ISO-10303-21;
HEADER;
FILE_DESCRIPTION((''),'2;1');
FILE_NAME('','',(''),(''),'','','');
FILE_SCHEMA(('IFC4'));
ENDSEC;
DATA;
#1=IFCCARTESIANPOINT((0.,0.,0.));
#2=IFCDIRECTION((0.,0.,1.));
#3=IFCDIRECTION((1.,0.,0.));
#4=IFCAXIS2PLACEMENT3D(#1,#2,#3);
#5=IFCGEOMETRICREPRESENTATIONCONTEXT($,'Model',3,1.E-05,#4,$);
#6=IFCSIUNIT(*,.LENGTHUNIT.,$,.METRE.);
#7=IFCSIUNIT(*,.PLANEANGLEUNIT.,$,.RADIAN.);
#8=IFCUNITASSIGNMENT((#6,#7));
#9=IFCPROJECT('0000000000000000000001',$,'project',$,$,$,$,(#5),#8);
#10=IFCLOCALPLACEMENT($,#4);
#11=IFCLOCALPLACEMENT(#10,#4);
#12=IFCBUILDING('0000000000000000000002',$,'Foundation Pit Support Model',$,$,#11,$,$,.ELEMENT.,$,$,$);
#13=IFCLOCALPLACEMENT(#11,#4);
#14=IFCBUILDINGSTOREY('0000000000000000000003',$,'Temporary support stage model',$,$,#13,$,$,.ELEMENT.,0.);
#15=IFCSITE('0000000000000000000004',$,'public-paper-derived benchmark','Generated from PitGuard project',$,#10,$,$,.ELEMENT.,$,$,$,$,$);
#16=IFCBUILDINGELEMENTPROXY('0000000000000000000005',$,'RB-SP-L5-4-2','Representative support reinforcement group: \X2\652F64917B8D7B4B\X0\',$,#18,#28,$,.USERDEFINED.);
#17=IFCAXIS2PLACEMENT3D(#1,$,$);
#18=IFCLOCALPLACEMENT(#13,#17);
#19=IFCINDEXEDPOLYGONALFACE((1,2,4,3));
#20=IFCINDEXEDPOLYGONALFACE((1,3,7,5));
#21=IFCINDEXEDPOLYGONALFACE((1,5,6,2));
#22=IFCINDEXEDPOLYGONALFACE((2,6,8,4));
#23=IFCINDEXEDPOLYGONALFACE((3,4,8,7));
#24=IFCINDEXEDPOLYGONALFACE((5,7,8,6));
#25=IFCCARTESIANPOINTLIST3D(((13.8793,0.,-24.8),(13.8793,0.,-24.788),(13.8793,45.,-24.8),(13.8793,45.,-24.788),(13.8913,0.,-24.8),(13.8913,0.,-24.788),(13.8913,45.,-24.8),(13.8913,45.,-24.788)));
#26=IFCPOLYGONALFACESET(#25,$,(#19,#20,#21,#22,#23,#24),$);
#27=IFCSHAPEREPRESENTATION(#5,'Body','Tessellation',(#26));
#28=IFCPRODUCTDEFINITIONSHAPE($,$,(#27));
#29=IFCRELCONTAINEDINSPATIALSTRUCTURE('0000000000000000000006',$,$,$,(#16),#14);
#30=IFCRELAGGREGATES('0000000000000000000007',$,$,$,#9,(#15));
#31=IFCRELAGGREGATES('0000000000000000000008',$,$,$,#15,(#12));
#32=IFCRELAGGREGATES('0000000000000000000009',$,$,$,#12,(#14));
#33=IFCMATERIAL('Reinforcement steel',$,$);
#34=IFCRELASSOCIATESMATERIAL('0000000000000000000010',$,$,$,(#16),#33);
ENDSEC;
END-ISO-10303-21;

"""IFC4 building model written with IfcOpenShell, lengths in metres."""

from ifc_helpers import new_model, si_unit, frame, origin_with_axes, origin_2d, place, context, project, spatial, rectangle, extrude, material, element, save


model = new_model("IFC4")

# Units and contexts
model_context = context("Model", 3, precision=1e-05, world=origin_with_axes())
ifc_project = project(units=[si_unit("LENGTHUNIT", "METRE"), si_unit("PLANEANGLEUNIT", "RADIAN")], contexts=[model_context])

# Site, building, storey
site_placement = place(None, origin_with_axes())
site = spatial("IfcSite", under=ifc_project, at=site_placement, Name="public-paper-derived benchmark", Description="Generated from PitGuard project", CompositionType="ELEMENT")
building_placement = place(site_placement, origin_with_axes())
building = spatial("IfcBuilding", under=site, at=building_placement, Name="Foundation Pit Support Model", CompositionType="ELEMENT")
storey_placement = place(building_placement, origin_with_axes())
storey = spatial("IfcBuildingStorey", under=building, at=storey_placement, Name="Temporary support stage model", CompositionType="ELEMENT", Elevation=0.0)

# Building element proxy
ifc_material_1 = material(Name="Reinforcement steel")
for number, where, z_axis, x_axis, name in (
    (1, (13.8853, 22.5, -24.8), (0.0, 0.0, 1.0), (0.0, 1.0, 0.0), "RB-SP-L5-4-2"),
):
    element("IfcBuildingElementProxy", number, at=place(storey_placement, frame(where, z_axis=z_axis, x_axis=x_axis)), inside=storey, material=ifc_material_1, Name=name, Description="Representative support reinforcement group: 支撑箍筋", PredefinedType="USERDEFINED", context=model_context, shape_type="SweptSolid", body=[
        extrude(rectangle(XDim=45.0, YDim=0.012, at=origin_2d()), origin_with_axes(), (0.0, 0.0, 1.0), 0.012),
    ])

save(model, "model.ifc")
